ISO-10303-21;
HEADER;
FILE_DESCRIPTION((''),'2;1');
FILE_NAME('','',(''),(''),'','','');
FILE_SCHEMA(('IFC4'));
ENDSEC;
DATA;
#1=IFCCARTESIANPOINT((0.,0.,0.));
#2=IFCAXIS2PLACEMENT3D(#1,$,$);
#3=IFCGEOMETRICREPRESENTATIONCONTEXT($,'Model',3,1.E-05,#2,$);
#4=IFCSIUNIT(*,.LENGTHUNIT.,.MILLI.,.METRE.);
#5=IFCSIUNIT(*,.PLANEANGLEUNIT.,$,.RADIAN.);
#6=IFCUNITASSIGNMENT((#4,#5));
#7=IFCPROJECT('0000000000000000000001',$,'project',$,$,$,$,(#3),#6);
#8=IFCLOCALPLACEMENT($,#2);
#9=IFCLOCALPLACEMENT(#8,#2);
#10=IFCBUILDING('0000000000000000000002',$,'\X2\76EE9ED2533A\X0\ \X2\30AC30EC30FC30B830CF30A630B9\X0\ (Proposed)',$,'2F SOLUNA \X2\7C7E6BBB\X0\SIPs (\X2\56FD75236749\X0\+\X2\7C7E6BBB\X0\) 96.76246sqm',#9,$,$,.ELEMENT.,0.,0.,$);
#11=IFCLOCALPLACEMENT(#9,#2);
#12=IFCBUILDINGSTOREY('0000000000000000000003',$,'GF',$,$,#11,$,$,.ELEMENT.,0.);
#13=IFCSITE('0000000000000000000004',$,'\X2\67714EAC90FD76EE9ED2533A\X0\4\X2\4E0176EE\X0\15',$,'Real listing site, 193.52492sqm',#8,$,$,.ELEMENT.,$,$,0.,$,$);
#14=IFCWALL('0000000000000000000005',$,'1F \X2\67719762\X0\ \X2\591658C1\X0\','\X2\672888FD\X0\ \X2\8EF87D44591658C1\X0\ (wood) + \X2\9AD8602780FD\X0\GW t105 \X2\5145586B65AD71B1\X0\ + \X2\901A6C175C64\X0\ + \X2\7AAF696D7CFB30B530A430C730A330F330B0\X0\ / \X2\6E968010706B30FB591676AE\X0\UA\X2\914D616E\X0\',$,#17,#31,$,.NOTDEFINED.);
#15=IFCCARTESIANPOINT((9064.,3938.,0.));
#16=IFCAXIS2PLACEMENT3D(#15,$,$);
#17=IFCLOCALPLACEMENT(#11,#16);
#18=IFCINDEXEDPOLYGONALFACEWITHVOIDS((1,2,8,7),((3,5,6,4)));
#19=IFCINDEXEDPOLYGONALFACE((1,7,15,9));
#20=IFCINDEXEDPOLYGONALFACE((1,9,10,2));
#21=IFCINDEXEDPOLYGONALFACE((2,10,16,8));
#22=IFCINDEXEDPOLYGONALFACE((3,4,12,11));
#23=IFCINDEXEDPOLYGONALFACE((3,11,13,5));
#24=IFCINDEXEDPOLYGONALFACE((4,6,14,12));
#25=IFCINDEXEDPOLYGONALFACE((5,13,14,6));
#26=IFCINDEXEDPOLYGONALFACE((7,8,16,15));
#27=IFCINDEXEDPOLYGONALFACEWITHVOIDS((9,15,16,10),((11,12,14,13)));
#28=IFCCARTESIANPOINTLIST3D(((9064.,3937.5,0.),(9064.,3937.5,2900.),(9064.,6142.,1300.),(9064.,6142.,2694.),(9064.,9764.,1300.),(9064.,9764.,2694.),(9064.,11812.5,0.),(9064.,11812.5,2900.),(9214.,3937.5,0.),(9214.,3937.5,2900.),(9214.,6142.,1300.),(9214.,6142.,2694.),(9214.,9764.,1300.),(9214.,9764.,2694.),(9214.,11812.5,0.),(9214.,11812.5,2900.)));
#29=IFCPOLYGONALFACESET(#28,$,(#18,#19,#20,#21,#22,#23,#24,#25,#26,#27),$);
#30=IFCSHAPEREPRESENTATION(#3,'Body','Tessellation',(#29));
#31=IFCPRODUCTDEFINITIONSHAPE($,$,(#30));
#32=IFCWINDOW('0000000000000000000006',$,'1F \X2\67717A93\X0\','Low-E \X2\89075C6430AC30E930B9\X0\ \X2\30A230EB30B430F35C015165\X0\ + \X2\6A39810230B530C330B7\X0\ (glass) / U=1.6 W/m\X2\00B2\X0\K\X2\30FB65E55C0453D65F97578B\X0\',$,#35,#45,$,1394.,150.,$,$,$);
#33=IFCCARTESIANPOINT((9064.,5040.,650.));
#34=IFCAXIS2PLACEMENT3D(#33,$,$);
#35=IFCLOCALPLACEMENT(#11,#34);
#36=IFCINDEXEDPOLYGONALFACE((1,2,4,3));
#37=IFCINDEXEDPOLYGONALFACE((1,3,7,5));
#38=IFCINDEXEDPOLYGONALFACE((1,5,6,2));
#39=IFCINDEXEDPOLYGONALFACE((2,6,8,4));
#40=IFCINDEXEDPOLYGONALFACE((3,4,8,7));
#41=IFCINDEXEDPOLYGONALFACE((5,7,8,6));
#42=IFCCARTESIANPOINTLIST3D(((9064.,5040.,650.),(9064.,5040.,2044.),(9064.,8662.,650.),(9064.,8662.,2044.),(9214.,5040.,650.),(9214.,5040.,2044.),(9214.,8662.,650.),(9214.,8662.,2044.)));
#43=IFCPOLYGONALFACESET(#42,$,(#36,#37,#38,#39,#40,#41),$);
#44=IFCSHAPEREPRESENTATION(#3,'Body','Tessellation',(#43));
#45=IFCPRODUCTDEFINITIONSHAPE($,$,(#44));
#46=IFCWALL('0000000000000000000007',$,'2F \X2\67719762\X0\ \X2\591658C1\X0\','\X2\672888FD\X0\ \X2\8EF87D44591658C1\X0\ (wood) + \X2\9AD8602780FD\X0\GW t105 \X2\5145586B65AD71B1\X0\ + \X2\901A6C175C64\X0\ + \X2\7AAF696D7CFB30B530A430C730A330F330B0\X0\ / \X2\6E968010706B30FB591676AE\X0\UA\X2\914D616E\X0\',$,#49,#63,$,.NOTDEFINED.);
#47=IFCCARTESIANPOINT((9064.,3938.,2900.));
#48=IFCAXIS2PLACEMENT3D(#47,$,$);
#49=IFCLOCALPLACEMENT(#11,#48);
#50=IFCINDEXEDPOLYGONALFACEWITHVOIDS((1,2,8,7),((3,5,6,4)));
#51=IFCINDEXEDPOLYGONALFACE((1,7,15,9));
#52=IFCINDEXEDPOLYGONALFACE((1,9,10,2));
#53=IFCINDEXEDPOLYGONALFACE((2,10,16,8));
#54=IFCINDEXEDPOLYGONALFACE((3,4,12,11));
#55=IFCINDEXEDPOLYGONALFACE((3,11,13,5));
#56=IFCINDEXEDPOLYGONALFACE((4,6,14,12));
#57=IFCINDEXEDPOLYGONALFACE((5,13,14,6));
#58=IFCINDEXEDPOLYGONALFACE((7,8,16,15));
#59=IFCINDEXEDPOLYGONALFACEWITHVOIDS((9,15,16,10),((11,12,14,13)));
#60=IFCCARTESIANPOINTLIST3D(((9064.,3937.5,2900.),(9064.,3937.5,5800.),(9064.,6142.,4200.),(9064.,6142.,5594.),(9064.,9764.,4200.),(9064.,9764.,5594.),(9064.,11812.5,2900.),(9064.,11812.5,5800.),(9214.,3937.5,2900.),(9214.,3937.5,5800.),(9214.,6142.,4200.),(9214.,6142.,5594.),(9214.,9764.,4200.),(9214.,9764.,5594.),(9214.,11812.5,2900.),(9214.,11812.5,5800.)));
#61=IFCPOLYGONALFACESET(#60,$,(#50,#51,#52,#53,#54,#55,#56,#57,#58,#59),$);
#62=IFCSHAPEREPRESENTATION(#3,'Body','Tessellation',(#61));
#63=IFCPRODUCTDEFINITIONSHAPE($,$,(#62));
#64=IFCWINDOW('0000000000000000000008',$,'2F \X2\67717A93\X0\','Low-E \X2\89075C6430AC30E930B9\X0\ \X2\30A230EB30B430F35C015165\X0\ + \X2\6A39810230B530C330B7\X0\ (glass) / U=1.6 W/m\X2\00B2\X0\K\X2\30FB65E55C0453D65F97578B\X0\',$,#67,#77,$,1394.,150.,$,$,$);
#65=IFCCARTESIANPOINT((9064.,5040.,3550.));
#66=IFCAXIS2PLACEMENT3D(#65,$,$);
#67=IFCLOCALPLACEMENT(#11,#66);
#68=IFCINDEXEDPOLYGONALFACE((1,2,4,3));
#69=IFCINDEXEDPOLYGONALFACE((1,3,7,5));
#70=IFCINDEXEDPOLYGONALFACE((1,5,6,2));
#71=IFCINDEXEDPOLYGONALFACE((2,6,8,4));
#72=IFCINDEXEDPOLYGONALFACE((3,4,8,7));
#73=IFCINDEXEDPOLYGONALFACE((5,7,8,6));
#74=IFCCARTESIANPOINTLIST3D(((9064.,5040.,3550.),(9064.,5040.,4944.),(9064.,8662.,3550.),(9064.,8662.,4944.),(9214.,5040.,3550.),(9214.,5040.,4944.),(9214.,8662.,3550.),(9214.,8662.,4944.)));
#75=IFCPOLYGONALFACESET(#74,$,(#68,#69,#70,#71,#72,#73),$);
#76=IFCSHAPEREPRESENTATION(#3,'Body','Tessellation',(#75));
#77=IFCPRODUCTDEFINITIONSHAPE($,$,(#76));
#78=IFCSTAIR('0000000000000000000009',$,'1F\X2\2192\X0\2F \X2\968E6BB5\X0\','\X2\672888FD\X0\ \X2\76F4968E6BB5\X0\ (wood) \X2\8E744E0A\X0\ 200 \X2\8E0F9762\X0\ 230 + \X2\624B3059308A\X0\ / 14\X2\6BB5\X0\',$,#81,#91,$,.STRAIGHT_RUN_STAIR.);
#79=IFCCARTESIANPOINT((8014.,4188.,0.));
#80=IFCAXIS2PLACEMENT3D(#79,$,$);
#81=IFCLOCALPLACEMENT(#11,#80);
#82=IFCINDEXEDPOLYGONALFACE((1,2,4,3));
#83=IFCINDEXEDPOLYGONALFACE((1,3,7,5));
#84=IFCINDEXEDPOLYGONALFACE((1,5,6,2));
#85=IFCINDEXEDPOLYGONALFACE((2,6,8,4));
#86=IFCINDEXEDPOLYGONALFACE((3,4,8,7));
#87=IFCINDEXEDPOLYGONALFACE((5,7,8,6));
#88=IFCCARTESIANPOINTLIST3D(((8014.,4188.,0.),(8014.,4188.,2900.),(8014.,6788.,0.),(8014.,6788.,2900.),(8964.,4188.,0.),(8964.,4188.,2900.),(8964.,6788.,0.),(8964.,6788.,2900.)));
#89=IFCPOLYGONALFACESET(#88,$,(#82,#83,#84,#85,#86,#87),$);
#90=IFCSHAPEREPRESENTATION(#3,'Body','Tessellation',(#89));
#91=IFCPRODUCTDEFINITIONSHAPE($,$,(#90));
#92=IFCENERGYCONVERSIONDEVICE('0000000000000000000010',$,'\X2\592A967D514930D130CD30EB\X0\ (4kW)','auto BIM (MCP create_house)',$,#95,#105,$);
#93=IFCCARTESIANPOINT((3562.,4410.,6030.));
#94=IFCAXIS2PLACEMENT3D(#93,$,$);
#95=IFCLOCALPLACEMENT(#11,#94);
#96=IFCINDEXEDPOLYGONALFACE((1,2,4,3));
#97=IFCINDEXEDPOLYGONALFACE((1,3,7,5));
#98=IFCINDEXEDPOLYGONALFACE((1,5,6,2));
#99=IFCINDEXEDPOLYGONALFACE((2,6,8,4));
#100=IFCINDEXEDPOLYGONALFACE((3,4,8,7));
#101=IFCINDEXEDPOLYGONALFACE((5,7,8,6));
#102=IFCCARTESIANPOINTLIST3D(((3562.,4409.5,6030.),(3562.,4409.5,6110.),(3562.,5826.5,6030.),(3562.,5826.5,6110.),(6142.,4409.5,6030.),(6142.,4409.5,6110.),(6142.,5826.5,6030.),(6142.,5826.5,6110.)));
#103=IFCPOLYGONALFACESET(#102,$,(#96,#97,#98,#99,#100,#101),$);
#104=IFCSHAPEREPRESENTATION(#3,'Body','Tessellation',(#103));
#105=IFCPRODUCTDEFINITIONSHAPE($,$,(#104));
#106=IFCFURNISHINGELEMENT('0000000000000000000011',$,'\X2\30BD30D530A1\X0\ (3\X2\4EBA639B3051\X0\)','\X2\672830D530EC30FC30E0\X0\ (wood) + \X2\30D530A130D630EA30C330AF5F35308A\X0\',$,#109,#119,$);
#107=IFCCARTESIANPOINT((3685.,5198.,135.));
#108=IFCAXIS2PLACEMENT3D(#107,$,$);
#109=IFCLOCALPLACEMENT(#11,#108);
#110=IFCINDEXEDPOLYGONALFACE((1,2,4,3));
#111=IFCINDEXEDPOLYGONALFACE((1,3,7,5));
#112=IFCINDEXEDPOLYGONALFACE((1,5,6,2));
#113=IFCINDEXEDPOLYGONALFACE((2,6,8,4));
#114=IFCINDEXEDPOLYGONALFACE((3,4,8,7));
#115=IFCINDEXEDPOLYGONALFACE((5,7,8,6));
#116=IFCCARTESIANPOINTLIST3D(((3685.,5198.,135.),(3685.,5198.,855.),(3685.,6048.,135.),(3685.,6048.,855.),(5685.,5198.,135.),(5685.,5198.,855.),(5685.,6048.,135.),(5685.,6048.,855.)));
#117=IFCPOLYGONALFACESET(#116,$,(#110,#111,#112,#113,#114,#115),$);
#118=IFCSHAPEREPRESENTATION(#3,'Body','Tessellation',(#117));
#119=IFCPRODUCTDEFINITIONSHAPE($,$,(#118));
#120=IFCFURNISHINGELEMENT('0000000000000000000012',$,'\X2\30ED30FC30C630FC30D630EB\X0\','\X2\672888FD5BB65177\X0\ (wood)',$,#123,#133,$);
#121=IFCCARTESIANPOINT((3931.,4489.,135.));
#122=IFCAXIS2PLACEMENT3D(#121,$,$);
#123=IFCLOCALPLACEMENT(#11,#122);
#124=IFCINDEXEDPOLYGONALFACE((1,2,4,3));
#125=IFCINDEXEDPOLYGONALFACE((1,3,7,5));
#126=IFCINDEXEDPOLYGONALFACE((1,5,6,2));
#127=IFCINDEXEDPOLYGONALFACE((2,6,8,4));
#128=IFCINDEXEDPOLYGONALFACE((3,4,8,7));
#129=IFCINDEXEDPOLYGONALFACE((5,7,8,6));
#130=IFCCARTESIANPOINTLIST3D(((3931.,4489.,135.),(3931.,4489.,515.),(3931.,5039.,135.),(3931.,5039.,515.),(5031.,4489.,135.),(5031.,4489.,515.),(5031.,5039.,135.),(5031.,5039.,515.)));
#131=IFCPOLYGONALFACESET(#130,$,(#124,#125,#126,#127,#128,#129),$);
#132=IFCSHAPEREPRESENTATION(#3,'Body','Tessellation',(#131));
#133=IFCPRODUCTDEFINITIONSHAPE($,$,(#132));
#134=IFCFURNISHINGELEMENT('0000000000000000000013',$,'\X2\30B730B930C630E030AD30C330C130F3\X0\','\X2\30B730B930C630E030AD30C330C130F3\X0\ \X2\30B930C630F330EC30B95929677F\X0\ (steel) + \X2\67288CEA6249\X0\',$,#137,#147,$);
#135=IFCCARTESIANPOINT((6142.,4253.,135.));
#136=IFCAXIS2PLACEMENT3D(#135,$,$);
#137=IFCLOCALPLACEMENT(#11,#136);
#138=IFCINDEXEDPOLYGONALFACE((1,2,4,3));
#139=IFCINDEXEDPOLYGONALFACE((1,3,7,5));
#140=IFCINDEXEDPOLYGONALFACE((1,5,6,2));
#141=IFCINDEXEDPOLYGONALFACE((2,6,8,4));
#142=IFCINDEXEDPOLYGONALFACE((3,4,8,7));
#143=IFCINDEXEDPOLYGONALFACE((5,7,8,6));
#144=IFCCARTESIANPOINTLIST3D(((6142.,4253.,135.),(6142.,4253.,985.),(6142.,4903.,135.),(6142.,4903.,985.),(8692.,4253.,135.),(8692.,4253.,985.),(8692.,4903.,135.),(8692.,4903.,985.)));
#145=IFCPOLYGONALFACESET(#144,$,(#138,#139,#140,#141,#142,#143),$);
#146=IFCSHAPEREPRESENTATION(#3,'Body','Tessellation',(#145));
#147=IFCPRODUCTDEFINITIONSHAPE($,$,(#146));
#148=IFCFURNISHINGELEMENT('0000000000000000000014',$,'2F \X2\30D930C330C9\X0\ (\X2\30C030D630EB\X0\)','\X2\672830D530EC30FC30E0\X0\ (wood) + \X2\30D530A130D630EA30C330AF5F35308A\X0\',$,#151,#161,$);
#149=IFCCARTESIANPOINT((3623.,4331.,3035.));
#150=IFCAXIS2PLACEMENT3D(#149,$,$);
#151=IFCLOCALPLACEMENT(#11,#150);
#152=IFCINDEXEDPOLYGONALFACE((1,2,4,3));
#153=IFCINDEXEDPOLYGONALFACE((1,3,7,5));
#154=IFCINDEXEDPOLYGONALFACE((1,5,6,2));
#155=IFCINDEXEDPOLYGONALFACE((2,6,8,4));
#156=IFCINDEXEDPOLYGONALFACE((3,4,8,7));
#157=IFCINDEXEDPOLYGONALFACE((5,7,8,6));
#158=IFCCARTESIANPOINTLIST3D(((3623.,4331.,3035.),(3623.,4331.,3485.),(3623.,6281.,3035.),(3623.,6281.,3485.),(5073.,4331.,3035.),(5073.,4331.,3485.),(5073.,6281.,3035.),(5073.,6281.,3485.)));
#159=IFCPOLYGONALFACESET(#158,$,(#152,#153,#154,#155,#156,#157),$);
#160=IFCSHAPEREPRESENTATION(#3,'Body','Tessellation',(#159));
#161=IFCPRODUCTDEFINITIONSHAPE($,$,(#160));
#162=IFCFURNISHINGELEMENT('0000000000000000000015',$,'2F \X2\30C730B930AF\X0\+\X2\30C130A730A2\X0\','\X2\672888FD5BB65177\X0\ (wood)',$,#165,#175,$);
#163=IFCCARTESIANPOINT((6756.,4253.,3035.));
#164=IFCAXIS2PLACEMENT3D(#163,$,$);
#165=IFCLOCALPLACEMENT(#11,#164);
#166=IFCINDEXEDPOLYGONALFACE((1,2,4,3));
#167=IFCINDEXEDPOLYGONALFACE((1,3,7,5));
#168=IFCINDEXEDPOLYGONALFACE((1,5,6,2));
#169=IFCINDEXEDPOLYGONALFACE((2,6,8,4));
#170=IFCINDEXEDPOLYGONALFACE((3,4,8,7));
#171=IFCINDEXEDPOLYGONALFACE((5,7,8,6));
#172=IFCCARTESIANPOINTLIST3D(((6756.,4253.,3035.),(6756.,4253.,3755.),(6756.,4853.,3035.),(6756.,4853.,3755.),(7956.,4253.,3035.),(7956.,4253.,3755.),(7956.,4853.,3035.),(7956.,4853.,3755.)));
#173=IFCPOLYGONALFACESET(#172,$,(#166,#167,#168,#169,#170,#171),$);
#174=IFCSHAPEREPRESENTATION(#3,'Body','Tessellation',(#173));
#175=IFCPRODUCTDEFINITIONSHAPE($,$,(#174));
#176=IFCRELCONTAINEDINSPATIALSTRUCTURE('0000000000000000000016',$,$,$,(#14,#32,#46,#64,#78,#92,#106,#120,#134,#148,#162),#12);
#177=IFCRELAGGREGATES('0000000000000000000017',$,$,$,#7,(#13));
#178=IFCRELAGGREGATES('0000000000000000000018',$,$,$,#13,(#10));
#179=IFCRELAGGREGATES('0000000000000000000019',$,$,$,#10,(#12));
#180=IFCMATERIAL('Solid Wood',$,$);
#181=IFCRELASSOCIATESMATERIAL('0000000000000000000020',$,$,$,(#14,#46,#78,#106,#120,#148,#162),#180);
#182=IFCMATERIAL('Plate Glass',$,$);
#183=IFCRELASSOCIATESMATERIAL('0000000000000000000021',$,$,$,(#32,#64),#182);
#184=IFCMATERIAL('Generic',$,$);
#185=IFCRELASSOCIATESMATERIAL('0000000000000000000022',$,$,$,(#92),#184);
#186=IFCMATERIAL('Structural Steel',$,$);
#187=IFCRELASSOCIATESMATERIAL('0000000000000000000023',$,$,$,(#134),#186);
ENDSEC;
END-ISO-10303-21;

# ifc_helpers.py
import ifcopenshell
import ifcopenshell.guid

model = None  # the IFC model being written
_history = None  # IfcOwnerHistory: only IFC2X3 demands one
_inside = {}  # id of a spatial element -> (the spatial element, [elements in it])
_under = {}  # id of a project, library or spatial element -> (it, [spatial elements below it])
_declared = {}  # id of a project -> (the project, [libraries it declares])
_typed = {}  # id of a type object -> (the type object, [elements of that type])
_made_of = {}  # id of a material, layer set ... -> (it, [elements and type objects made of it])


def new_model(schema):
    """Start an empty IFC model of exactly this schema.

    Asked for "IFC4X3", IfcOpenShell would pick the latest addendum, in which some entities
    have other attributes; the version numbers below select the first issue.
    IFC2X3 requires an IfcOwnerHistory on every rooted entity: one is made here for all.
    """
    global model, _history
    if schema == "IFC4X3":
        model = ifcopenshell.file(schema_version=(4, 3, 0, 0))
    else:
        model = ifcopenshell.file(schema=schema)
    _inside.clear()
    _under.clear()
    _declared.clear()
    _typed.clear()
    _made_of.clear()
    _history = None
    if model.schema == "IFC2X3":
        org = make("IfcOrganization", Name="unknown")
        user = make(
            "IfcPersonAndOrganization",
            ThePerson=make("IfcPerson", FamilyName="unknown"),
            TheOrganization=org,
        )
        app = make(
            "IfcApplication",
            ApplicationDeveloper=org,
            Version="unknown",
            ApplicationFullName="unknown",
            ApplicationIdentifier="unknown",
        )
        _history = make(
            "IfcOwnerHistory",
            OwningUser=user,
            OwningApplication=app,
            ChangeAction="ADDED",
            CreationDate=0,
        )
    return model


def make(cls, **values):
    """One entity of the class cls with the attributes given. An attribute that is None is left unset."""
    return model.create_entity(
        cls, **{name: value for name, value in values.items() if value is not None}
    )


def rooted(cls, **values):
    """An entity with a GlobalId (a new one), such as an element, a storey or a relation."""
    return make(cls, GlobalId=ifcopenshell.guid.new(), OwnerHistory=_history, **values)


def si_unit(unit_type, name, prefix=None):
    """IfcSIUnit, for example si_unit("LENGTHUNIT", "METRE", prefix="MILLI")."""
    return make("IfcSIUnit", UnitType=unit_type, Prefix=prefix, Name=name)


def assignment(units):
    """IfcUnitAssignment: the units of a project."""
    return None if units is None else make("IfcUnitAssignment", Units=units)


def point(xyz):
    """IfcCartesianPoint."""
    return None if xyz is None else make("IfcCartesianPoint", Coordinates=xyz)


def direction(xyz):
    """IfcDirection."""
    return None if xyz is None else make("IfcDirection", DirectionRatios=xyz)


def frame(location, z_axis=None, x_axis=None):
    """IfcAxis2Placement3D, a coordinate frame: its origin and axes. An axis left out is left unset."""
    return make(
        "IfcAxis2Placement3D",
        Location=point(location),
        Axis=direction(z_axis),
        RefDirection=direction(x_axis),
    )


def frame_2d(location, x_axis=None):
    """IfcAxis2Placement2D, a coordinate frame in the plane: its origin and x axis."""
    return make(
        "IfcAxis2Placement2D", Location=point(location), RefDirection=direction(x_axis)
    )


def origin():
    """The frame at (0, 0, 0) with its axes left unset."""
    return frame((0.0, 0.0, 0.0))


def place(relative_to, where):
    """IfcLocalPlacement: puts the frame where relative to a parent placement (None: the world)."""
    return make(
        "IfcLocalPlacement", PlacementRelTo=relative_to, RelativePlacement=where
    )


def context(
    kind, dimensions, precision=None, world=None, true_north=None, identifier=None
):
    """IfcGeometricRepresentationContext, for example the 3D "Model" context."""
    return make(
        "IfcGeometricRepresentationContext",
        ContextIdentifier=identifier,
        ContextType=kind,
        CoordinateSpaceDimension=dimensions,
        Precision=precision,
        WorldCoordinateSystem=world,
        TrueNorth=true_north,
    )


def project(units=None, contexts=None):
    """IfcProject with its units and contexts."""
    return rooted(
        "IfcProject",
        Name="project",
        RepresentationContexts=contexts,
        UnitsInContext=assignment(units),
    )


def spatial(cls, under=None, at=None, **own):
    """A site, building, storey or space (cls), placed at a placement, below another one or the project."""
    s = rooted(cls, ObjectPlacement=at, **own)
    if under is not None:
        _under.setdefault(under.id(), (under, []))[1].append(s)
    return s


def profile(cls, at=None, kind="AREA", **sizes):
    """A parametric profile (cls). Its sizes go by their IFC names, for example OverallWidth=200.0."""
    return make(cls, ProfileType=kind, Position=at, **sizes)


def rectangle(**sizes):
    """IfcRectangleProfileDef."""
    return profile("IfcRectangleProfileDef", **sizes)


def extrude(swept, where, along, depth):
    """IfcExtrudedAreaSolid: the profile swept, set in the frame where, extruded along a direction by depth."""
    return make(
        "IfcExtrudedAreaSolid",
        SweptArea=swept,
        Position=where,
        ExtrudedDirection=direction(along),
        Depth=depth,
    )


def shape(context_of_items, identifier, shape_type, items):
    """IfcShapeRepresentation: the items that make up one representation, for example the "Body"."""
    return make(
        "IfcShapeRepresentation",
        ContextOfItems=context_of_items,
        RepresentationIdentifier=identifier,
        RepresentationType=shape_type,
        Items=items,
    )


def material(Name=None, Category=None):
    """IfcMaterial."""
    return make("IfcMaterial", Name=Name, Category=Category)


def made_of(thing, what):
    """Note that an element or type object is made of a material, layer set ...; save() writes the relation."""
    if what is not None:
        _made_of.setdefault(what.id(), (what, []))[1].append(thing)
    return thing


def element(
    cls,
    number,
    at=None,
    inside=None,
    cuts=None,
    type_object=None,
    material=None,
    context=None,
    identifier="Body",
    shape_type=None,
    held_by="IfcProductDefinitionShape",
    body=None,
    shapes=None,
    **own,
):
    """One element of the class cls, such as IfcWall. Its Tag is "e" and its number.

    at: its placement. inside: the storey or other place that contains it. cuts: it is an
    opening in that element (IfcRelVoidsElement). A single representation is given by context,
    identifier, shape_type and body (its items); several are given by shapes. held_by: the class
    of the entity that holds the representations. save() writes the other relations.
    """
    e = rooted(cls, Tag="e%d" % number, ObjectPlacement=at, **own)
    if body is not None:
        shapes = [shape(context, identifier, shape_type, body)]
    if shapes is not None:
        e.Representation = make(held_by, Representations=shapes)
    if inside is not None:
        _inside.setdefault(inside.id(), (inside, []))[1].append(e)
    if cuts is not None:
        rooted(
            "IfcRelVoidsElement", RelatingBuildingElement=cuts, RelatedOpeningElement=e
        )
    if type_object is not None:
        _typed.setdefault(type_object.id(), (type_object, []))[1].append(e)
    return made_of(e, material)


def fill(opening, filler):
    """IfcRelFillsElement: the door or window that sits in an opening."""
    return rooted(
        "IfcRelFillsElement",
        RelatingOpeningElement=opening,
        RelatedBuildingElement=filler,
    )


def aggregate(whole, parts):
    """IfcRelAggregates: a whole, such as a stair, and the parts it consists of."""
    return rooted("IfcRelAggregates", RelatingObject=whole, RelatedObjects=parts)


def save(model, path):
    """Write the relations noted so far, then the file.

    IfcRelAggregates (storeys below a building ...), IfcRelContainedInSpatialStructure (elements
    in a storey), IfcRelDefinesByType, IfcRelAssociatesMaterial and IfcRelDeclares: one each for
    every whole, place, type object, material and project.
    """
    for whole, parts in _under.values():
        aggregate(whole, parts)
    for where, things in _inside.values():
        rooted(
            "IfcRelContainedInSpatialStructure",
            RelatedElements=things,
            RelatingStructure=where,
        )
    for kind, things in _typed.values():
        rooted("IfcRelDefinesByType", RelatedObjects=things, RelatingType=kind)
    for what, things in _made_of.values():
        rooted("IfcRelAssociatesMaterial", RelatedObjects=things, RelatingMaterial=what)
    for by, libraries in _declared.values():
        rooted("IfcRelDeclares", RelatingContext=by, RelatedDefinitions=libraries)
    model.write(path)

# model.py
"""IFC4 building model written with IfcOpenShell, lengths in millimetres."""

from ifc_helpers import new_model, si_unit, frame, frame_2d, origin, place, context, project, spatial, rectangle, extrude, material, element, fill, save


model = new_model("IFC4")

# Units and contexts
model_context = context("Model", 3, precision=1e-05, world=origin())
ifc_project = project(units=[si_unit("LENGTHUNIT", "METRE", prefix="MILLI"), si_unit("PLANEANGLEUNIT", "RADIAN")], contexts=[model_context])

# Site, building, storey
site_placement = place(None, origin())
site = spatial("IfcSite", under=ifc_project, at=site_placement, Name="東京都目黒区4丁目15", ObjectType="Real listing site, 193.52492sqm", CompositionType="ELEMENT", RefElevation=0.0)
building_placement = place(site_placement, origin())
building = spatial("IfcBuilding", under=site, at=building_placement, Name="目黒区 ガレージハウス (Proposed)", ObjectType="2F SOLUNA 籾殻SIPs (国産杉+籾殻) 96.76246sqm", CompositionType="ELEMENT", ElevationOfRefHeight=0.0, ElevationOfTerrain=0.0)
storey_placement = place(building_placement, origin())
storey = spatial("IfcBuildingStorey", under=building, at=storey_placement, Name="GF", CompositionType="ELEMENT", Elevation=0.0)

# Wall, opening, window
ifc_material_1 = material(Name="Solid Wood")
wall_1_placement = place(storey_placement, frame((9064.0, 3938.0, 0.0)))
wall_1 = element("IfcWall", 1, at=wall_1_placement, inside=storey, material=ifc_material_1, Name="1F 東面 外壁", Description="木製 軸組外壁 (wood) + 高性能GW t105 充填断熱 + 通気層 + 窯業系サイディング / 準耐火・外皮UA配慮", PredefinedType="NOTDEFINED", context=model_context, shape_type="SweptSolid", body=[
    extrude(rectangle(XDim=150.0, YDim=7875.0, at=frame_2d((75.0, 3937.0))), frame((9064.0, 3938.0, 0.0)), (0.0, 0.0, 1.0), 2900.0),
])
opening_1_placement = place(storey_placement, frame((9064.0, 5040.0, 650.0)))
opening_1 = element("IfcOpeningElement", 2, at=opening_1_placement, cuts=wall_1, PredefinedType="NOTDEFINED", context=model_context, shape_type="SweptSolid", body=[
    extrude(rectangle(XDim=150.0, YDim=3622.0, at=frame_2d((75.0, 1811.0))), frame((9064.0, 5040.0, 650.0)), (0.0, 0.0, 1.0), 1394.0),
])
ifc_material_2 = material(Name="Plate Glass")
window_1_placement = place(storey_placement, frame((9064.0, 5040.0, 650.0)))
window_1 = element("IfcWindow", 3, at=window_1_placement, inside=storey, material=ifc_material_2, Name="1F 東窓", Description="Low-E 複層ガラス アルゴン封入 + 樹脂サッシ (glass) / U=1.6 W/m²K・日射取得型", OverallHeight=1394.0, OverallWidth=150.0, context=model_context, shape_type="SweptSolid", body=[
    extrude(rectangle(XDim=150.0, YDim=3622.0, at=frame_2d((75.0, 1811.0))), frame((9064.0, 5040.0, 650.0)), (0.0, 0.0, 1.0), 1394.0),
])
fill(opening_1, window_1)

# Wall, opening, window
wall_2_placement = place(storey_placement, frame((9064.0, 3938.0, 2900.0)))
wall_2 = element("IfcWall", 4, at=wall_2_placement, inside=storey, material=ifc_material_1, Name="2F 東面 外壁", Description="木製 軸組外壁 (wood) + 高性能GW t105 充填断熱 + 通気層 + 窯業系サイディング / 準耐火・外皮UA配慮", PredefinedType="NOTDEFINED", context=model_context, shape_type="SweptSolid", body=[
    extrude(rectangle(XDim=150.0, YDim=7875.0, at=frame_2d((75.0, 3937.0))), frame((9064.0, 3938.0, 2900.0)), (0.0, 0.0, 1.0), 2900.0),
])
opening_2_placement = place(storey_placement, frame((9064.0, 5040.0, 3550.0)))
opening_2 = element("IfcOpeningElement", 5, at=opening_2_placement, cuts=wall_2, PredefinedType="NOTDEFINED", context=model_context, shape_type="SweptSolid", body=[
    extrude(rectangle(XDim=150.0, YDim=3622.0, at=frame_2d((75.0, 1811.0))), frame((9064.0, 5040.0, 3550.0)), (0.0, 0.0, 1.0), 1394.0),
])
window_2_placement = place(storey_placement, frame((9064.0, 5040.0, 3550.0)))
window_2 = element("IfcWindow", 6, at=window_2_placement, inside=storey, material=ifc_material_2, Name="2F 東窓", Description="Low-E 複層ガラス アルゴン封入 + 樹脂サッシ (glass) / U=1.6 W/m²K・日射取得型", OverallHeight=1394.0, OverallWidth=150.0, context=model_context, shape_type="SweptSolid", body=[
    extrude(rectangle(XDim=150.0, YDim=3622.0, at=frame_2d((75.0, 1811.0))), frame((9064.0, 5040.0, 3550.0)), (0.0, 0.0, 1.0), 1394.0),
])
fill(opening_2, window_2)

# Stair
stair_placement = place(storey_placement, frame((8014.0, 4188.0, 0.0)))
element("IfcStair", 7, at=stair_placement, inside=storey, material=ifc_material_1, Name="1F→2F 階段", Description="木製 直階段 (wood) 蹴上 200 踏面 230 + 手すり / 14段", PredefinedType="STRAIGHT_RUN_STAIR", context=model_context, shape_type="SweptSolid", body=[
    extrude(rectangle(XDim=950.0, YDim=2600.0, at=frame_2d((475.0, 1300.0))), frame((8014.0, 4188.0, 0.0)), (0.0, 0.0, 1.0), 2900.0),
])

# Energy conversion device
ifc_material_3 = material(Name="Generic")
energy_conversion_device_placement = place(storey_placement, frame((3562.0, 4410.0, 6030.0)))
element("IfcEnergyConversionDevice", 8, at=energy_conversion_device_placement, inside=storey, material=ifc_material_3, Name="太陽光パネル (4kW)", Description="auto BIM (MCP create_house)", context=model_context, shape_type="SweptSolid", body=[
    extrude(rectangle(XDim=2580.0, YDim=1417.0, at=frame_2d((1290.0, 708.0))), frame((3562.0, 4410.0, 6030.0)), (0.0, 0.0, 1.0), 80.0),
])

# Furnishing elements
furnishing_1_placement = place(storey_placement, frame((3685.0, 5198.0, 135.0)))
element("IfcFurnishingElement", 9, at=furnishing_1_placement, inside=storey, material=ifc_material_1, Name="ソファ (3人掛け)", Description="木フレーム (wood) + ファブリック張り", context=model_context, shape_type="SweptSolid", body=[
    extrude(rectangle(XDim=2000.0, YDim=850.0, at=frame_2d((1000.0, 425.0))), frame((3685.0, 5198.0, 135.0)), (0.0, 0.0, 1.0), 720.0),
])
furnishing_2_placement = place(storey_placement, frame((3931.0, 4489.0, 135.0)))
element("IfcFurnishingElement", 10, at=furnishing_2_placement, inside=storey, material=ifc_material_1, Name="ローテーブル", Description="木製家具 (wood)", context=model_context, shape_type="SweptSolid", body=[
    extrude(rectangle(XDim=1100.0, YDim=550.0, at=frame_2d((550.0, 275.0))), frame((3931.0, 4489.0, 135.0)), (0.0, 0.0, 1.0), 380.0),
])
ifc_material_4 = material(Name="Structural Steel")
furnishing_3_placement = place(storey_placement, frame((6142.0, 4253.0, 135.0)))
element("IfcFurnishingElement", 11, at=furnishing_3_placement, inside=storey, material=ifc_material_4, Name="システムキッチン", Description="システムキッチン ステンレス天板 (steel) + 木質扉", context=model_context, shape_type="SweptSolid", body=[
    extrude(rectangle(XDim=2550.0, YDim=650.0, at=frame_2d((1275.0, 325.0))), frame((6142.0, 4253.0, 135.0)), (0.0, 0.0, 1.0), 850.0),
])
furnishing_4_placement = place(storey_placement, frame((3623.0, 4331.0, 3035.0)))
element("IfcFurnishingElement", 12, at=furnishing_4_placement, inside=storey, material=ifc_material_1, Name="2F ベッド (ダブル)", Description="木フレーム (wood) + ファブリック張り", context=model_context, shape_type="SweptSolid", body=[
    extrude(rectangle(XDim=1450.0, YDim=1950.0, at=frame_2d((725.0, 975.0))), frame((3623.0, 4331.0, 3035.0)), (0.0, 0.0, 1.0), 450.0),
])
furnishing_5_placement = place(storey_placement, frame((6756.0, 4253.0, 3035.0)))
element("IfcFurnishingElement", 13, at=furnishing_5_placement, inside=storey, material=ifc_material_1, Name="2F デスク+チェア", Description="木製家具 (wood)", context=model_context, shape_type="SweptSolid", body=[
    extrude(rectangle(XDim=1200.0, YDim=600.0, at=frame_2d((600.0, 300.0))), frame((6756.0, 4253.0, 3035.0)), (0.0, 0.0, 1.0), 720.0),
])

save(model, "model.ifc")
